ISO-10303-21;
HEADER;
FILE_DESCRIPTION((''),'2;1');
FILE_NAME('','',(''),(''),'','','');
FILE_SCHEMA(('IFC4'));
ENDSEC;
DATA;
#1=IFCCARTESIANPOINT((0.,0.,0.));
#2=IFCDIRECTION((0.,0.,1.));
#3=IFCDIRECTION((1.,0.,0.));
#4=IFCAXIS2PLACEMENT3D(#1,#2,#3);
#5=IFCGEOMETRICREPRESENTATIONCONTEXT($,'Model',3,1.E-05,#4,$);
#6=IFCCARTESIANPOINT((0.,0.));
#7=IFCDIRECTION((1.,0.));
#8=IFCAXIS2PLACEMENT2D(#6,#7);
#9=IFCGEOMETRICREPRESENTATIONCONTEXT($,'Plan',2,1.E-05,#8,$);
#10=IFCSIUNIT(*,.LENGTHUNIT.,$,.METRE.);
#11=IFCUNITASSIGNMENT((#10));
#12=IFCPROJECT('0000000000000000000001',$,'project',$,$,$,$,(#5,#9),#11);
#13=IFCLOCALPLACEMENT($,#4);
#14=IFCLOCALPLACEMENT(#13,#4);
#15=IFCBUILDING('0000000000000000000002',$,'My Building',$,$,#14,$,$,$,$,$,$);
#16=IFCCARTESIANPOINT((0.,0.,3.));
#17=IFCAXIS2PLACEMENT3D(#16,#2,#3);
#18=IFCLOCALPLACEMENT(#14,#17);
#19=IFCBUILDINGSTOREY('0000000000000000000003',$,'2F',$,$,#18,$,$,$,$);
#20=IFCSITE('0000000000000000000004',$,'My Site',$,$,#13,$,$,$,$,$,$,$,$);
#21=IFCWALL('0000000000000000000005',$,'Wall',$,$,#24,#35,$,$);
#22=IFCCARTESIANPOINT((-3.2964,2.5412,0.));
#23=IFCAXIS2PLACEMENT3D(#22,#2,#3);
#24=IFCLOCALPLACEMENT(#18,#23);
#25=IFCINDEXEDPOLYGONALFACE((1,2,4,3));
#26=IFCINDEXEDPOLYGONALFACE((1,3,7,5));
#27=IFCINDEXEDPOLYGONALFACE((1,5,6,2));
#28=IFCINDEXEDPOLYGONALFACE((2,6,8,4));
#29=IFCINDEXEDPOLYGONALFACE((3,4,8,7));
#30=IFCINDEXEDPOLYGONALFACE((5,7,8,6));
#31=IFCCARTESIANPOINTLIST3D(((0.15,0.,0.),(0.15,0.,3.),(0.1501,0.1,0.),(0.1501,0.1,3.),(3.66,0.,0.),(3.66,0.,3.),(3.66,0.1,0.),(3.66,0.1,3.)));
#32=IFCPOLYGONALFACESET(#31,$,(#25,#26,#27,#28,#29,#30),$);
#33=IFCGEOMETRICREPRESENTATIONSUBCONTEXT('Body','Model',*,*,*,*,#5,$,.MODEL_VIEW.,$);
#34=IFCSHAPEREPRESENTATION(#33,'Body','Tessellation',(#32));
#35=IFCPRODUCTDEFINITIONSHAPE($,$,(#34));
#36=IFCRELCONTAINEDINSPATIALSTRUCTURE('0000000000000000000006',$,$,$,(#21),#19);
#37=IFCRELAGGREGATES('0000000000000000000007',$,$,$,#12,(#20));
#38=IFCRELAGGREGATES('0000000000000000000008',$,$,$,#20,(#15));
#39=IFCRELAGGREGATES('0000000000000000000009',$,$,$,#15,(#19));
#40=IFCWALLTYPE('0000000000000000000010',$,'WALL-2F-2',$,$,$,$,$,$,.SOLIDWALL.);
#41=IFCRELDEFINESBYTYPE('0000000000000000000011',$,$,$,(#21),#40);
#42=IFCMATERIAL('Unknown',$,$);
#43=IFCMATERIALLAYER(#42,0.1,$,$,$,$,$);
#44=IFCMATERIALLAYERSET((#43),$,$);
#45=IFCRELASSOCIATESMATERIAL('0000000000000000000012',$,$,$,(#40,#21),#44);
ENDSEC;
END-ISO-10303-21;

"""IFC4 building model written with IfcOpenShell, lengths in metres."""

from ifc_helpers import new_model, si_unit, frame, origin_with_axes, origin_2d_with_axis, place, context, subcontext, project, spatial, line, indexed_curve, outline, extrude, material, layer, layer_set, layer_usage, type_object, element, save


model = new_model("IFC4")

# Units and contexts
model_context = context("Model", 3, precision=1e-05, world=origin_with_axes())
plan_context = context("Plan", 2, precision=1e-05, world=origin_2d_with_axis())
body_context_1 = subcontext(model_context, "Body", "Model", "MODEL_VIEW")
ifc_project = project(units=[si_unit("LENGTHUNIT", "METRE")], contexts=[model_context, plan_context])

# Site, building, storey
site_placement = place(None, origin_with_axes())
site = spatial("IfcSite", under=ifc_project, at=site_placement, Name="My Site")
building_placement = place(site_placement, origin_with_axes())
building = spatial("IfcBuilding", under=site, at=building_placement, Name="My Building")
storey_placement = place(building_placement, frame((0.0, 0.0, 3.0), z_axis=(0.0, 0.0, 1.0), x_axis=(1.0, 0.0, 0.0)))
storey = spatial("IfcBuildingStorey", under=building, at=storey_placement, Name="2F")

# Shared definitions
ifc_material = material(Name="Unknown")

# Shared definitions
ifc_layer_1 = layer(ifc_material, 0.1)
ifc_layer_set_1 = layer_set([ifc_layer_1])
wall_type_1 = type_object("IfcWallType", Name="WALL-2F-2", PredefinedType="SOLIDWALL", material=ifc_layer_set_1)

# Wall
ifc_layer_usage_1 = layer_usage(ifc_layer_set_1, "AXIS2", "POSITIVE", 0.0)
wall_1_placement = place(storey_placement, frame((-3.2964, 2.5412, 0.0), z_axis=(0.0, 0.0, 1.0), x_axis=(1.0, 0.0, 0.0)))
element("IfcWall", 1, at=wall_1_placement, inside=storey, type_object=wall_type_1, material=ifc_layer_usage_1, Name="Wall", context=body_context_1, shape_type="SweptSolid", body=[
    extrude(outline(indexed_curve([(0.15, 0.0), (0.1501, 0.1), (3.66, 0.1), (3.66, 0.0)], segments=[line(1, 2, 3, 4, 1)])), origin_with_axes(), (0.0, 0.0, 1.0), 3.0),
])

save(model, "model.ifc")
